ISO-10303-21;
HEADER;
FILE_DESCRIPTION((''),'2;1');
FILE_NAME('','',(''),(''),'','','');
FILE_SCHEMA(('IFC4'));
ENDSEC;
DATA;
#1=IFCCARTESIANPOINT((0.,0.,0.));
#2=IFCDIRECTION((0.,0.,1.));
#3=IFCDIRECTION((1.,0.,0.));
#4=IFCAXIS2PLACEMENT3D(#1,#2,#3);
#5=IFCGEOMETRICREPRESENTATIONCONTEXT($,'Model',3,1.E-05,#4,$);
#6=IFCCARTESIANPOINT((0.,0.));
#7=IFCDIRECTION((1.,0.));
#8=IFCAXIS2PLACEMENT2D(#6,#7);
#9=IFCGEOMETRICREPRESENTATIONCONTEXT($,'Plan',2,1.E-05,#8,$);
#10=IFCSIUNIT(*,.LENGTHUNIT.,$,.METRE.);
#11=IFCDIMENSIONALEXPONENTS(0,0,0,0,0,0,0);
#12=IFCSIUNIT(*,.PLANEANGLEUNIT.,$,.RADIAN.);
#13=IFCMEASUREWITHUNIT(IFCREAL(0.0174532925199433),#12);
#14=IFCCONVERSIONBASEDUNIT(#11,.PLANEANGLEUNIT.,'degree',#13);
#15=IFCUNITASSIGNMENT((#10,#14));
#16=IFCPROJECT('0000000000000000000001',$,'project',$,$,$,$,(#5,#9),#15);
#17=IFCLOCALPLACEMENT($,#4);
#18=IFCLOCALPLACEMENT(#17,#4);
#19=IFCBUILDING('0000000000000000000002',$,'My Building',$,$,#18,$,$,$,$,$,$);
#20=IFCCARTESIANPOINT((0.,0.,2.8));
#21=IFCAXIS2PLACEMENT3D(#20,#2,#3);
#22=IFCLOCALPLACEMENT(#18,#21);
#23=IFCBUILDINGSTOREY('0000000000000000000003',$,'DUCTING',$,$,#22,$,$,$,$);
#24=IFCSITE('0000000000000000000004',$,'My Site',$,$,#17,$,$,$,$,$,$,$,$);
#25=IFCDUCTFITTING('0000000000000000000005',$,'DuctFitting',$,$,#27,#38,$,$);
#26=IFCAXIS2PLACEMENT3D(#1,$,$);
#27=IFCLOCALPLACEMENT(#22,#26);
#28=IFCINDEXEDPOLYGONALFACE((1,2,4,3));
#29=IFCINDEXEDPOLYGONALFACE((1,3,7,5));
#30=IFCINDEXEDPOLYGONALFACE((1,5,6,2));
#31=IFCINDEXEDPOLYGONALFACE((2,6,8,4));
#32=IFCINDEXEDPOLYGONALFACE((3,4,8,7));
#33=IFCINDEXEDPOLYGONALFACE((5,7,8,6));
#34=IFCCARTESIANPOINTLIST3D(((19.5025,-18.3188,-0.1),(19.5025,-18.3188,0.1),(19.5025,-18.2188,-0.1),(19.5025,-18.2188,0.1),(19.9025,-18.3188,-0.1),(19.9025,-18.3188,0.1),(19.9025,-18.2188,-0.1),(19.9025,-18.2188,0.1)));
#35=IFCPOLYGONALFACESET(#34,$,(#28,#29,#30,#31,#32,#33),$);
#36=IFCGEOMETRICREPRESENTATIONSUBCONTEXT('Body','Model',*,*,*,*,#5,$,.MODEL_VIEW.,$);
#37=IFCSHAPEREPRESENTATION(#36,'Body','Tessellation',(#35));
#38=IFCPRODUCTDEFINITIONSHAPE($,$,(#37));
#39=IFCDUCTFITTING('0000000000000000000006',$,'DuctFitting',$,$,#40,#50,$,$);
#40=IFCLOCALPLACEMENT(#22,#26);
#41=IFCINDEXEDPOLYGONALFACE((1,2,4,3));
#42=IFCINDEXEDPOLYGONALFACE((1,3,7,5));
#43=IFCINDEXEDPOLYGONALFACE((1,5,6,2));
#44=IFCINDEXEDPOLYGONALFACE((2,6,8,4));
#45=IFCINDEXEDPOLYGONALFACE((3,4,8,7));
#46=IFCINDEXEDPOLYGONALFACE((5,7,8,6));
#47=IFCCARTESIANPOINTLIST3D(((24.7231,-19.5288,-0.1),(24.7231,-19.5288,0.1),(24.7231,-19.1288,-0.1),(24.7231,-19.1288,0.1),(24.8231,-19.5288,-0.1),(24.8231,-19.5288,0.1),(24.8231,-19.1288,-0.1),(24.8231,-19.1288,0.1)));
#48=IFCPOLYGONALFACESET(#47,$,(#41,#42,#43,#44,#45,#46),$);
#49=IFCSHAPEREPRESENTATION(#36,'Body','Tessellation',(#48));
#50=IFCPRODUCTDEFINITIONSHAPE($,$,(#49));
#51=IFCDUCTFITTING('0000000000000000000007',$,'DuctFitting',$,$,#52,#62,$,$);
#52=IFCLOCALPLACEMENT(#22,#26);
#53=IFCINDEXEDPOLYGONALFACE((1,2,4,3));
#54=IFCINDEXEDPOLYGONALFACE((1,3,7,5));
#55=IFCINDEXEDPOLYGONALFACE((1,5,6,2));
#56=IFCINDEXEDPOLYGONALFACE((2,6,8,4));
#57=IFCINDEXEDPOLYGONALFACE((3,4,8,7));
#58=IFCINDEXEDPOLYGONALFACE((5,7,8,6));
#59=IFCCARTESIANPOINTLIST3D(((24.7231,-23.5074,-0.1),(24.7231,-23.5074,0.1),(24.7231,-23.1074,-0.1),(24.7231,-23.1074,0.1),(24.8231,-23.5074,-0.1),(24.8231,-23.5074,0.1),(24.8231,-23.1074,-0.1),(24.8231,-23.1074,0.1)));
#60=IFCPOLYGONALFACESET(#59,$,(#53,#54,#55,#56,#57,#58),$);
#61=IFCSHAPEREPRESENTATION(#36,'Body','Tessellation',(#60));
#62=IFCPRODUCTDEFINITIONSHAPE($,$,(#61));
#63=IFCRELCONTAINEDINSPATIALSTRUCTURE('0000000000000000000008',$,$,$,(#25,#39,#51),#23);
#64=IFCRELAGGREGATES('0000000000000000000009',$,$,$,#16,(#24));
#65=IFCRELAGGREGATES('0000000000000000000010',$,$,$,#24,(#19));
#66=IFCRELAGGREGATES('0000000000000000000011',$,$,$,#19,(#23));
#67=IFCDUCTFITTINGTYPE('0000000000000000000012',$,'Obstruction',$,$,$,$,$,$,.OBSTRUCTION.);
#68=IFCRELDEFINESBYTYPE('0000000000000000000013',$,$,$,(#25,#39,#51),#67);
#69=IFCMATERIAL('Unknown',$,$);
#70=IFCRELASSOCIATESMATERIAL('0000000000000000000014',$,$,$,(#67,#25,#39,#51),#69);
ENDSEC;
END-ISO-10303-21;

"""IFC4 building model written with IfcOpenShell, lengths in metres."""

from ifc_helpers import new_model, entity, si_unit, converted_unit, frame, origin_with_axes, origin_2d_with_axis, place, context, subcontext, project, spatial, rectangle, extrude, material, material_profile, profile_set, profile_usage, type_object, element, save


model = new_model("IFC4")

# Units and contexts
model_context = context("Model", 3, precision=1e-05, world=origin_with_axes())
plan_context = context("Plan", 2, precision=1e-05, world=origin_2d_with_axis())
body_context = subcontext(model_context, "Body", "Model", "MODEL_VIEW")
ifc_project = project(units=[si_unit("LENGTHUNIT", "METRE"), converted_unit("PLANEANGLEUNIT", "degree", entity("IfcReal", 0.0174532925199433), si_unit("PLANEANGLEUNIT", "RADIAN"), dimensions=[0, 0, 0, 0, 0, 0, 0])], contexts=[model_context, plan_context])

# Site, building, storey
site_placement = place(None, origin_with_axes())
site = spatial("IfcSite", under=ifc_project, at=site_placement, Name="My Site")
building_placement = place(site_placement, origin_with_axes())
building = spatial("IfcBuilding", under=site, at=building_placement, Name="My Building")
storey_placement = place(building_placement, frame((0.0, 0.0, 2.8), z_axis=(0.0, 0.0, 1.0), x_axis=(1.0, 0.0, 0.0)))
storey = spatial("IfcBuildingStorey", under=building, at=storey_placement, Name="DUCTING")

# Shared definitions
ifc_material = material(Name="Unknown")

# Duct fittings
ifc_material_profile_1 = material_profile(ifc_material, rectangle(XDim=0.4, YDim=0.2))
ifc_profile_set_1 = profile_set([ifc_material_profile_1])
duct_fitting_type_1 = type_object("IfcDuctFittingType", Name="Obstruction", PredefinedType="OBSTRUCTION", material=ifc_profile_set_1)
ifc_profile_usage_1 = profile_usage(ifc_profile_set_1, cardinal=5)
duct_fitting_1_placement = place(storey_placement, frame((19.7025, -18.2188, 0.0), z_axis=(0.0, -1.0, 0.0), x_axis=(1.0, 0.0, 0.0)))
element("IfcDuctFitting", 1, at=duct_fitting_1_placement, inside=storey, type_object=duct_fitting_type_1, material=ifc_profile_usage_1, Name="DuctFitting", context=body_context, shape_type="SweptSolid", body=[
    extrude(rectangle(XDim=0.4, YDim=0.2), origin_with_axes(), (0.0, 0.0, 1.0), 0.1),
])
ifc_profile_usage_2 = profile_usage(ifc_profile_set_1, cardinal=5)
duct_fitting_2_placement = place(storey_placement, frame((24.7231, -19.3288, 0.0), z_axis=(1.0, 0.0, 0.0), x_axis=(0.0, 1.0, 0.0)))
element("IfcDuctFitting", 2, at=duct_fitting_2_placement, inside=storey, type_object=duct_fitting_type_1, material=ifc_profile_usage_2, Name="DuctFitting", context=body_context, shape_type="SweptSolid", body=[
    extrude(rectangle(XDim=0.4, YDim=0.2), origin_with_axes(), (0.0, 0.0, 1.0), 0.1),
])
ifc_profile_usage_3 = profile_usage(ifc_profile_set_1, cardinal=5)
duct_fitting_3_placement = place(storey_placement, frame((24.7231, -23.3074, 0.0), z_axis=(1.0, 0.0, 0.0), x_axis=(0.0, 1.0, 0.0)))
element("IfcDuctFitting", 3, at=duct_fitting_3_placement, inside=storey, type_object=duct_fitting_type_1, material=ifc_profile_usage_3, Name="DuctFitting", context=body_context, shape_type="SweptSolid", body=[
    extrude(rectangle(XDim=0.4, YDim=0.2), origin_with_axes(), (0.0, 0.0, 1.0), 0.1),
])

save(model, "model.ifc")
